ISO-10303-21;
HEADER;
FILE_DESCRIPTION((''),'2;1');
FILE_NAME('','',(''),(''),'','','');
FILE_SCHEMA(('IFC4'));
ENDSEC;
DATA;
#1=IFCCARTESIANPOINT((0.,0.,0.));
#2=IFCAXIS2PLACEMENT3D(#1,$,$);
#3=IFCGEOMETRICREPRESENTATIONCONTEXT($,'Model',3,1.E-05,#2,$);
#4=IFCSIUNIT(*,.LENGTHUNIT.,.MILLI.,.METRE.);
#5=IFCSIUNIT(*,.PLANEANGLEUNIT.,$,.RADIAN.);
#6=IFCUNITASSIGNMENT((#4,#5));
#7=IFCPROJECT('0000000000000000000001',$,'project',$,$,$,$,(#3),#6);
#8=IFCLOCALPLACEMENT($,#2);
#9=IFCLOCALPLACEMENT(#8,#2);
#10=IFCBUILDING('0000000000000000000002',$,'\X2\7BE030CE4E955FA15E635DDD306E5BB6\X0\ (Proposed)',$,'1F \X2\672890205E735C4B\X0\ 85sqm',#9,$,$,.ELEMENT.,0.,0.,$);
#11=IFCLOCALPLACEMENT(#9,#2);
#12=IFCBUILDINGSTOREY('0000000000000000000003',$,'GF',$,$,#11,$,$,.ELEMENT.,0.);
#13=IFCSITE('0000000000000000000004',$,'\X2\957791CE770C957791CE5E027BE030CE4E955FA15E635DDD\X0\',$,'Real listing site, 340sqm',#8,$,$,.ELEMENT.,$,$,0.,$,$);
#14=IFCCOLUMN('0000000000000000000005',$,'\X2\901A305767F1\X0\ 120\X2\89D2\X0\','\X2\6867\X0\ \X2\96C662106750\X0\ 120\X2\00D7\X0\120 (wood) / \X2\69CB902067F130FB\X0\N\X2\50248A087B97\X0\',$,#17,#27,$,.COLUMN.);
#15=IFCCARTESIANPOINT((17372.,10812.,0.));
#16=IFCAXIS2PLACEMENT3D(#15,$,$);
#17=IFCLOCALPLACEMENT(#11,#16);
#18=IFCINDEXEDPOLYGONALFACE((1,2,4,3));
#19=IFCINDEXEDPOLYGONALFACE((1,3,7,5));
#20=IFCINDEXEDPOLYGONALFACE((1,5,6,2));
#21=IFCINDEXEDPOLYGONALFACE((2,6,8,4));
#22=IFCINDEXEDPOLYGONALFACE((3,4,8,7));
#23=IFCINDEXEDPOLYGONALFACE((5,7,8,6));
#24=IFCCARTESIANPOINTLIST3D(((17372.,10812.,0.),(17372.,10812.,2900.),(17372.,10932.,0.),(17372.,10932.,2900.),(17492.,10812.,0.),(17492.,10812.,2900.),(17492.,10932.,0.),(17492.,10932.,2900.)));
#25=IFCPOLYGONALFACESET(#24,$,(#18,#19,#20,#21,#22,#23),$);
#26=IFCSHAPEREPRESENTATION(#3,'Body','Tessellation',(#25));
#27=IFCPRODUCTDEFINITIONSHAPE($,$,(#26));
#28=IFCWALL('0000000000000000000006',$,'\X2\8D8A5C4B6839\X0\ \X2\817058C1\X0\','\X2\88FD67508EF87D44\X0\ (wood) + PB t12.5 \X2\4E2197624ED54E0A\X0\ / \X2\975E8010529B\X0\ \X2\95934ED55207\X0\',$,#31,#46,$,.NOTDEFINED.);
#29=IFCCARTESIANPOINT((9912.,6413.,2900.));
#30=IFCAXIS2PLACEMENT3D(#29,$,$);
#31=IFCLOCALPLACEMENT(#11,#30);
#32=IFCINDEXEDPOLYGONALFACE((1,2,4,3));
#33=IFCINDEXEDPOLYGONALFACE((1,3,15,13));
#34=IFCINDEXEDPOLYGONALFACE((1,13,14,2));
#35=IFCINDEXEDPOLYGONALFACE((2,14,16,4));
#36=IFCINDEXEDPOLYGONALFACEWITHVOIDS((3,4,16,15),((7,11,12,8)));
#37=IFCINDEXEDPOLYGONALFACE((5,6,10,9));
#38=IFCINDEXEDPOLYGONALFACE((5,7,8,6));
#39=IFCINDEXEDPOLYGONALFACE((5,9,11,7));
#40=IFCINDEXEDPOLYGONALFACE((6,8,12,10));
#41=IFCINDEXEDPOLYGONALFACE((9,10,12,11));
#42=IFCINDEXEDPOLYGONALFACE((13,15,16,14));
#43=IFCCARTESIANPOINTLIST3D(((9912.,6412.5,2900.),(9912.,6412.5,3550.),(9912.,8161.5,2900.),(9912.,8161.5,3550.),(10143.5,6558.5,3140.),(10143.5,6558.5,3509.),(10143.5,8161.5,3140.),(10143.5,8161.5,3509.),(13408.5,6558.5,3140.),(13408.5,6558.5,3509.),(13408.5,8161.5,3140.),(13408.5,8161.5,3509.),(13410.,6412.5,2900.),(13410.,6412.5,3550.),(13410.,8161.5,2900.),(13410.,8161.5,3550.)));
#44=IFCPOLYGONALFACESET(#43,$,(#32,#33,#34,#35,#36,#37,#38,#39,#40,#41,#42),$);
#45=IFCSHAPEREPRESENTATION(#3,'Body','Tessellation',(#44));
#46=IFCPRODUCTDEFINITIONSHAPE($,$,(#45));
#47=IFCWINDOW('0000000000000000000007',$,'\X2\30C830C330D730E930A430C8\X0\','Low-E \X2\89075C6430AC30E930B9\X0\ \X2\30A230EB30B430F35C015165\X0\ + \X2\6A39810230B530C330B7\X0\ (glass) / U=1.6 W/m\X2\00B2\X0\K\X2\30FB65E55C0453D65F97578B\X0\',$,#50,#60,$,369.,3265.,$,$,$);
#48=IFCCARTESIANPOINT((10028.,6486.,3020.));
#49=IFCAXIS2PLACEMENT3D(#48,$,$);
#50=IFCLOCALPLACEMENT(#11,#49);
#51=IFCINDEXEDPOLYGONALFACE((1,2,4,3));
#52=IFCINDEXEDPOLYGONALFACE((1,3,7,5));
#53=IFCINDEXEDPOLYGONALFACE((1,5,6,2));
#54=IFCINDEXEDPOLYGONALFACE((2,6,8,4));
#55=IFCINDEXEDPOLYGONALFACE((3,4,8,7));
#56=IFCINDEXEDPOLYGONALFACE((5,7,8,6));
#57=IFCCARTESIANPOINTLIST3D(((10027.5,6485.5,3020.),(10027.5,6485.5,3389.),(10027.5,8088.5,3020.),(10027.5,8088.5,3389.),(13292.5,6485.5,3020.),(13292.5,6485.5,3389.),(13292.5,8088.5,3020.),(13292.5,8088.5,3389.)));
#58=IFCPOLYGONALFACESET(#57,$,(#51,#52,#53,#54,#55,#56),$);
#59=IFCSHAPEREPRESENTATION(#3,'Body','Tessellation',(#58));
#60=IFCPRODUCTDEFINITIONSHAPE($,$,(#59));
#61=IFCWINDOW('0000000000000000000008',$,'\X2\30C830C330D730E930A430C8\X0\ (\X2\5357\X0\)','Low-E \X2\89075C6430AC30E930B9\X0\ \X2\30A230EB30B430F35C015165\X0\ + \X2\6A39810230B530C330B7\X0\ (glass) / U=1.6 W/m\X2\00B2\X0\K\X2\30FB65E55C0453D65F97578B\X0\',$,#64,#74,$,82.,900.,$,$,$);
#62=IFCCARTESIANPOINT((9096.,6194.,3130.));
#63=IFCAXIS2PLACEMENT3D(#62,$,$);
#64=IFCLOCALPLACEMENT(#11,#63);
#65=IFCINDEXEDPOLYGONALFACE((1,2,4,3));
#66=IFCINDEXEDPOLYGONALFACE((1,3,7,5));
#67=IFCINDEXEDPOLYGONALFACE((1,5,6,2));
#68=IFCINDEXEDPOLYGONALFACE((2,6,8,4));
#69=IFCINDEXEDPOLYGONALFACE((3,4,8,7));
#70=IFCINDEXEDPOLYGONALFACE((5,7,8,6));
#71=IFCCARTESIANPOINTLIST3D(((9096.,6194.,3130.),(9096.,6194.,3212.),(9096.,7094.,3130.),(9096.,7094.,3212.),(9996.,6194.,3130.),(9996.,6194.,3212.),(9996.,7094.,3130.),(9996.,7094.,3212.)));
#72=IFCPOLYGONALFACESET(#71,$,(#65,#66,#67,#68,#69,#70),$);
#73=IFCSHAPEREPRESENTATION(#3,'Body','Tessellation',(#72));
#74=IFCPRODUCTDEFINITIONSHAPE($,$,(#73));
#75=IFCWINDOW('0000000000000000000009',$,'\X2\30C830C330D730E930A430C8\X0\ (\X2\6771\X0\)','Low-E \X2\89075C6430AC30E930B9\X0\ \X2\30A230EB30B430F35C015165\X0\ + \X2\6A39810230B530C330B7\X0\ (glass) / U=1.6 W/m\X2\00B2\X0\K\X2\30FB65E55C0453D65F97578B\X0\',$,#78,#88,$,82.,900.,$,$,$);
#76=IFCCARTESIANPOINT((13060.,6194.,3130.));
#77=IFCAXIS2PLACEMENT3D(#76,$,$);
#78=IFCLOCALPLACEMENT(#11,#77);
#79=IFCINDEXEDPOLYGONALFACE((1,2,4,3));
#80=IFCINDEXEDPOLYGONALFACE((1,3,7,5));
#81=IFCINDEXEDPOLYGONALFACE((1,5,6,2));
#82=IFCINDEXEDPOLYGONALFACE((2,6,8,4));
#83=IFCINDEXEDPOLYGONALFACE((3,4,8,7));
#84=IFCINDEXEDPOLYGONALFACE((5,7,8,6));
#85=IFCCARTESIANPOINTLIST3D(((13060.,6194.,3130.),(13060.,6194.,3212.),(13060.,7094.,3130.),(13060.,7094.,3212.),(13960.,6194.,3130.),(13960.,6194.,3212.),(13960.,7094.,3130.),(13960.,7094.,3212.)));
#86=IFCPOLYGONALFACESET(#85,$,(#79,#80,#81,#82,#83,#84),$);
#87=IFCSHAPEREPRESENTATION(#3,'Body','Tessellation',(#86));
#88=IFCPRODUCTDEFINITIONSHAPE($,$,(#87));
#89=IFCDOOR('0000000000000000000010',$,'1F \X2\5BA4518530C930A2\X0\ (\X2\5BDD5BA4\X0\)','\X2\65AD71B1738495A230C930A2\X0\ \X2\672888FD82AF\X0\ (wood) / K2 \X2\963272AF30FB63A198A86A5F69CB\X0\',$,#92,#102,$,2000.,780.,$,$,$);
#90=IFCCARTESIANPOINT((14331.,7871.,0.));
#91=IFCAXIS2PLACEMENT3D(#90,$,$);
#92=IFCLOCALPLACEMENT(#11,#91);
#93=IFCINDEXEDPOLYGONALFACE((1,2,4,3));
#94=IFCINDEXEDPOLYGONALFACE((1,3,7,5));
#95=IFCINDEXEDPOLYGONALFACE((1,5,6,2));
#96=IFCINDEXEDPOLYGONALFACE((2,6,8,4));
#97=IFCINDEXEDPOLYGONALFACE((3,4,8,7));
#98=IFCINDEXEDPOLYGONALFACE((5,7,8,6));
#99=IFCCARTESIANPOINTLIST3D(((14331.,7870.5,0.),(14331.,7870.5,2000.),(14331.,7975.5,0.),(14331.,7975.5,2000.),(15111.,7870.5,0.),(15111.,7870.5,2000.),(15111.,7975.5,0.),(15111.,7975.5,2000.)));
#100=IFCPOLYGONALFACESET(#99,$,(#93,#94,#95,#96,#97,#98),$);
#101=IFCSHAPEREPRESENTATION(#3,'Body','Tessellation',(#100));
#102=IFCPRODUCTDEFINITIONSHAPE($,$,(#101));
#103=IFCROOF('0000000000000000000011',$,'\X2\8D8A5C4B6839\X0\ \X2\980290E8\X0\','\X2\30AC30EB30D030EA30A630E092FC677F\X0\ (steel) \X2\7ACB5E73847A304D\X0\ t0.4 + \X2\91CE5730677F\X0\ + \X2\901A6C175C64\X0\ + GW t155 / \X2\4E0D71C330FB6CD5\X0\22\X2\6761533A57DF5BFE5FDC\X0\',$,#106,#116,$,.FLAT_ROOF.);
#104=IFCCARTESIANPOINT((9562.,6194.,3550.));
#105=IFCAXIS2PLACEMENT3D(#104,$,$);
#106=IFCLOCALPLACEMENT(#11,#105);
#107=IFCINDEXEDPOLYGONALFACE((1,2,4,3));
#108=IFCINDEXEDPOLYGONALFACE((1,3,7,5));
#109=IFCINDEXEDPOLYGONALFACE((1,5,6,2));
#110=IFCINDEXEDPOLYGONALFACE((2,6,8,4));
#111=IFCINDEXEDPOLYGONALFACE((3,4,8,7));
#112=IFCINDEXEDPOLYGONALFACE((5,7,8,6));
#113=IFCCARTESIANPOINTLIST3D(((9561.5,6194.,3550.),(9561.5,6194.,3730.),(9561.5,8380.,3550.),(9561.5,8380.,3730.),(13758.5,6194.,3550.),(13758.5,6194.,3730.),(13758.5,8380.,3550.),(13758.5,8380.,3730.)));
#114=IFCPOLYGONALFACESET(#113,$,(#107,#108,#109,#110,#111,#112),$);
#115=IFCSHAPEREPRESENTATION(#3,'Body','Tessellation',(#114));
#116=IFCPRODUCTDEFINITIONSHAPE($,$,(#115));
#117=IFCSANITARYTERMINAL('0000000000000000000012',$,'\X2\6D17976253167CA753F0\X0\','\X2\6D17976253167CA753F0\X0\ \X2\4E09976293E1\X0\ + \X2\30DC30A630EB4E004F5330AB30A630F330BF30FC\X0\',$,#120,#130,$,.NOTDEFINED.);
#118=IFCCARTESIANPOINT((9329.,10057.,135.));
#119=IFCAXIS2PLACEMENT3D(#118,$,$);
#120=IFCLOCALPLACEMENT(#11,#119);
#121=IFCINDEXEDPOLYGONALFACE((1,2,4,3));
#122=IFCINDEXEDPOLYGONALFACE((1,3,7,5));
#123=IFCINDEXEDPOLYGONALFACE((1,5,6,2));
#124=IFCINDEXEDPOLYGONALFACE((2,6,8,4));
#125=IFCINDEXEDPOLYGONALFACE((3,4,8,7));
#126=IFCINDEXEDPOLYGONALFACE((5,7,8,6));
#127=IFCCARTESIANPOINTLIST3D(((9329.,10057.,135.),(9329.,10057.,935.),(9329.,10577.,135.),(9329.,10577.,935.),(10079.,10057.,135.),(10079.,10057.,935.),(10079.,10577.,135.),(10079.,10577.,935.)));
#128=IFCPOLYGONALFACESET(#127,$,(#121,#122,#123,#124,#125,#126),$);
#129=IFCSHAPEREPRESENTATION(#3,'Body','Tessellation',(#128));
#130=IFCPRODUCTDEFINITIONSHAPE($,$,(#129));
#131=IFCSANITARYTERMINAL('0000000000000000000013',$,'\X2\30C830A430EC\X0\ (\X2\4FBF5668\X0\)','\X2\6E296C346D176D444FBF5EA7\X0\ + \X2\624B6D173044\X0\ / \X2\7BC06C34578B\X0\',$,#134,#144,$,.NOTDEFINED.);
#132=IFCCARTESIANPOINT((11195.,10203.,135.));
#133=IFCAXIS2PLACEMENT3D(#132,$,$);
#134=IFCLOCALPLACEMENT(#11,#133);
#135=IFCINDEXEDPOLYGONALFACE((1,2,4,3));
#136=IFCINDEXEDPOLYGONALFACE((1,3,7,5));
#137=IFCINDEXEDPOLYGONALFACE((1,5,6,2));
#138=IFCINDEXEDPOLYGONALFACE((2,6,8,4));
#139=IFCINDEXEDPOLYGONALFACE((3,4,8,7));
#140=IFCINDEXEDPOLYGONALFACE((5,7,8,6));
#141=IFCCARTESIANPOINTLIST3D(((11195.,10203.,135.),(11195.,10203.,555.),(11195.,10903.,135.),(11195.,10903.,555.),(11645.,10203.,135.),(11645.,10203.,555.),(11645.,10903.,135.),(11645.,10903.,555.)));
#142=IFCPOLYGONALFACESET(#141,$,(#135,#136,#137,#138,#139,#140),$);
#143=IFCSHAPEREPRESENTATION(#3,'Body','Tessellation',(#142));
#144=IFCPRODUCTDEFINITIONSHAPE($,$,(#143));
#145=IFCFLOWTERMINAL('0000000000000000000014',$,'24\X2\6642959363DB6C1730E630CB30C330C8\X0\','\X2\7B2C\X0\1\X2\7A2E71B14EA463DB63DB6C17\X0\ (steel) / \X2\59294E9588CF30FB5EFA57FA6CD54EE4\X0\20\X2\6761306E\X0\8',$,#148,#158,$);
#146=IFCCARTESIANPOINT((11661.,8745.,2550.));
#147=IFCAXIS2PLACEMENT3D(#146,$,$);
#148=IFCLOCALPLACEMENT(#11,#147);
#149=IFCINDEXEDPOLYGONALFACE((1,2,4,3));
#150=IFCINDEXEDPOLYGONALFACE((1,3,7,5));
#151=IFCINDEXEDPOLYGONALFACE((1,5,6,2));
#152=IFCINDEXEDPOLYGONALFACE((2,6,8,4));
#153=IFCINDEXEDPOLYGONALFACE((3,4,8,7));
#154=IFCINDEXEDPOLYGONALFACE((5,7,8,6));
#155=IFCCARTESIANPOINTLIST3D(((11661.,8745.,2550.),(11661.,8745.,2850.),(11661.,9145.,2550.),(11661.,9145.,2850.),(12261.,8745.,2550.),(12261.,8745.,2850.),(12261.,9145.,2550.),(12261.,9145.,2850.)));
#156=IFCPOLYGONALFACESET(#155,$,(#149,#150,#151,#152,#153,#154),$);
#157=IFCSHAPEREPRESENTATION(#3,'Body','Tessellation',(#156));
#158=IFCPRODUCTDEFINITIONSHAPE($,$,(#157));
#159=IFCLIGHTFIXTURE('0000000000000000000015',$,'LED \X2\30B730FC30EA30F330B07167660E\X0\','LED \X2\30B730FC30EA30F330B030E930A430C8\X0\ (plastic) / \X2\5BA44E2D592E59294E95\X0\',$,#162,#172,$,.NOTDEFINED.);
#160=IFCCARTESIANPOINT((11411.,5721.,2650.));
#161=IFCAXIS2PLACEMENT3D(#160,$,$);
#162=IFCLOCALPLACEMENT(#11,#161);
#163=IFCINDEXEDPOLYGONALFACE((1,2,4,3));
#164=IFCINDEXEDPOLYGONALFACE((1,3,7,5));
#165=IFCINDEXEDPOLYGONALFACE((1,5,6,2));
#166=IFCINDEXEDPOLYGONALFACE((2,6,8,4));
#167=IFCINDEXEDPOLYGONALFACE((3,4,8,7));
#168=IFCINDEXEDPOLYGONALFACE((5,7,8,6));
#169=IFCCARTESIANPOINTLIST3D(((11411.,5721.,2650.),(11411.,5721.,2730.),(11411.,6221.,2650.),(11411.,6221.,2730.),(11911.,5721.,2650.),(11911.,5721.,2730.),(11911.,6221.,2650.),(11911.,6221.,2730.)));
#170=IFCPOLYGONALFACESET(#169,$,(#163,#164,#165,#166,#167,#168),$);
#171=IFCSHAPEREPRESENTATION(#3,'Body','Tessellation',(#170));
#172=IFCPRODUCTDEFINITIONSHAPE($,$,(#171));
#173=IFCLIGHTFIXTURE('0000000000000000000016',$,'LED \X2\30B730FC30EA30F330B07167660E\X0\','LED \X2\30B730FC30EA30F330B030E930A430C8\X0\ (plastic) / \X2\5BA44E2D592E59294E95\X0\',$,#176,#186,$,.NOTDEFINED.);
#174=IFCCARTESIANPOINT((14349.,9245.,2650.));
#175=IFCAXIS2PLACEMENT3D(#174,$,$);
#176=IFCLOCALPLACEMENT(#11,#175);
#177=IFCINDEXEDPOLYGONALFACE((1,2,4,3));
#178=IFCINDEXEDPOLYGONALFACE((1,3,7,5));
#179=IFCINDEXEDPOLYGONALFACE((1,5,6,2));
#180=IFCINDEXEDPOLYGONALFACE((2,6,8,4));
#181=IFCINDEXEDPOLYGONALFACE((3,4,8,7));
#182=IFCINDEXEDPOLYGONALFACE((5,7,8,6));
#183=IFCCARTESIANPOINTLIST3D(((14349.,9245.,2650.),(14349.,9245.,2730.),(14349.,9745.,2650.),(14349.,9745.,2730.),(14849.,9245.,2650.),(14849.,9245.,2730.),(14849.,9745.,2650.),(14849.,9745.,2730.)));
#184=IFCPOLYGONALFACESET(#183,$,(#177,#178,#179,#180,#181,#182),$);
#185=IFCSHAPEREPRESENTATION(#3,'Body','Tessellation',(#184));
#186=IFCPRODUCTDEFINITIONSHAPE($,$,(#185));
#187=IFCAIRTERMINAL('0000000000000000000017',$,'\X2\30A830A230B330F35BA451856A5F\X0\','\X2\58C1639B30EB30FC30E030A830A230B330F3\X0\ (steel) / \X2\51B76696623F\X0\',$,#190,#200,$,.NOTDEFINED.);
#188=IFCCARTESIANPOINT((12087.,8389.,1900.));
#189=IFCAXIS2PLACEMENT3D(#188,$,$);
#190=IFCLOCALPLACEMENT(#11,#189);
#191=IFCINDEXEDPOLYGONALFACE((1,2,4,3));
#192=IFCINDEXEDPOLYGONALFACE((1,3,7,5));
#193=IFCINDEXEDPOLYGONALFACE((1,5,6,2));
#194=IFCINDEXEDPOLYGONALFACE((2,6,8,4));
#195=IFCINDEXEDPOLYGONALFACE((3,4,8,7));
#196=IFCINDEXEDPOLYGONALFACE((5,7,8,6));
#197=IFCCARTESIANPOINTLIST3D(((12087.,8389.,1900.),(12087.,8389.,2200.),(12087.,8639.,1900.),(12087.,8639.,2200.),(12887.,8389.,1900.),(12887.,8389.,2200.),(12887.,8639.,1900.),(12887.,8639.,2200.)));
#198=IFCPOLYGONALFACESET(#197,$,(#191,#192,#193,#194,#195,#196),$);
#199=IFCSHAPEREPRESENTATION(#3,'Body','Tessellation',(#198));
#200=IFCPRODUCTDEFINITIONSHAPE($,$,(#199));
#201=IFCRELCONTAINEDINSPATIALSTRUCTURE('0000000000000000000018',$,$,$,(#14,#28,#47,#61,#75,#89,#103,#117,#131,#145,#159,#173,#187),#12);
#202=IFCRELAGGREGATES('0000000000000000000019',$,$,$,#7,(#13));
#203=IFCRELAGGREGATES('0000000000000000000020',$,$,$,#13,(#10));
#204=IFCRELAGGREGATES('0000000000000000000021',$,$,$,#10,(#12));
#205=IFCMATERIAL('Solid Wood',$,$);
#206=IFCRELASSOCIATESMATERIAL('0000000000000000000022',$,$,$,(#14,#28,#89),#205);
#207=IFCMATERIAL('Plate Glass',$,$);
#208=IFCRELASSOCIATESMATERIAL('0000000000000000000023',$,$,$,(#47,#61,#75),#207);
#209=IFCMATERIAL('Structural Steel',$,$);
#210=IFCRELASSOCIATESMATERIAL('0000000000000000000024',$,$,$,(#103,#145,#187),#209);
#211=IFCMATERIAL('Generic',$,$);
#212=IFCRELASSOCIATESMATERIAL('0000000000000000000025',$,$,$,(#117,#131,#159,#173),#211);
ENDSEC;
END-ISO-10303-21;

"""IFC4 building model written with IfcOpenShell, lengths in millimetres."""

from ifc_helpers import new_model, si_unit, frame, frame_2d, origin, place, context, project, spatial, rectangle, extrude, material, element, fill, save


model = new_model("IFC4")

# Units and contexts
model_context = context("Model", 3, precision=1e-05, world=origin())
ifc_project = project(units=[si_unit("LENGTHUNIT", "METRE", prefix="MILLI"), si_unit("PLANEANGLEUNIT", "RADIAN")], contexts=[model_context])

# Site, building, storey
site_placement = place(None, origin())
site = spatial("IfcSite", under=ifc_project, at=site_placement, Name="長野県長野市篠ノ井御幣川", ObjectType="Real listing site, 340sqm", CompositionType="ELEMENT", RefElevation=0.0)
building_placement = place(site_placement, origin())
building = spatial("IfcBuilding", under=site, at=building_placement, Name="篠ノ井御幣川の家 (Proposed)", ObjectType="1F 木造平屋 85sqm", CompositionType="ELEMENT", ElevationOfRefHeight=0.0, ElevationOfTerrain=0.0)
storey_placement = place(building_placement, origin())
storey = spatial("IfcBuildingStorey", under=building, at=storey_placement, Name="GF", CompositionType="ELEMENT", Elevation=0.0)

# Column
ifc_material_1 = material(Name="Solid Wood")
column_1_placement = place(storey_placement, frame((17372.0, 10812.0, 0.0)))
element("IfcColumn", 1, at=column_1_placement, inside=storey, material=ifc_material_1, Name="通し柱 120角", Description="桧 集成材 120×120 (wood) / 構造柱・N値計算", PredefinedType="COLUMN", context=model_context, shape_type="SweptSolid", body=[
    extrude(rectangle(XDim=120.0, YDim=120.0, at=frame_2d((60.0, 60.0))), frame((17372.0, 10812.0, 0.0)), (0.0, 0.0, 1.0), 2900.0),
])

# Wall, openings, windows
wall_1_placement = place(storey_placement, frame((9912.0, 6413.0, 2900.0)))
wall_1 = element("IfcWall", 2, at=wall_1_placement, inside=storey, material=ifc_material_1, Name="越屋根 腰壁", Description="製材軸組 (wood) + PB t12.5 両面仕上 / 非耐力 間仕切", PredefinedType="NOTDEFINED", context=model_context, shape_type="SweptSolid", body=[
    extrude(rectangle(XDim=3498.0, YDim=1749.0, at=frame_2d((1749.0, 874.0))), frame((9912.0, 6413.0, 2900.0)), (0.0, 0.0, 1.0), 650.0),
])
opening_1_placement = place(storey_placement, frame((10028.0, 6486.0, 3020.0)))
opening_1 = element("IfcOpeningElement", 3, at=opening_1_placement, cuts=wall_1, PredefinedType="NOTDEFINED", context=model_context, shape_type="SweptSolid", body=[
    extrude(rectangle(XDim=3265.0, YDim=1603.0, at=frame_2d((1632.0, 801.0))), frame((10028.0, 6486.0, 3020.0)), (0.0, 0.0, 1.0), 369.0),
])
opening_2_placement = place(storey_placement, frame((9096.0, 6194.0, 3130.0)))
opening_2 = element("IfcOpeningElement", 4, at=opening_2_placement, cuts=wall_1, PredefinedType="NOTDEFINED", context=model_context, shape_type="SweptSolid", body=[
    extrude(rectangle(XDim=900.0, YDim=900.0, at=frame_2d((450.0, 450.0))), frame((9096.0, 6194.0, 3130.0)), (0.0, 0.0, 1.0), 82.0),
])
opening_3_placement = place(storey_placement, frame((13060.0, 6194.0, 3130.0)))
opening_3 = element("IfcOpeningElement", 5, at=opening_3_placement, cuts=wall_1, PredefinedType="NOTDEFINED", context=model_context, shape_type="SweptSolid", body=[
    extrude(rectangle(XDim=900.0, YDim=900.0, at=frame_2d((450.0, 450.0))), frame((13060.0, 6194.0, 3130.0)), (0.0, 0.0, 1.0), 82.0),
])
ifc_material_2 = material(Name="Plate Glass")
window_1_placement = place(storey_placement, frame((10028.0, 6486.0, 3020.0)))
window_1 = element("IfcWindow", 6, at=window_1_placement, inside=storey, material=ifc_material_2, Name="トップライト", Description="Low-E 複層ガラス アルゴン封入 + 樹脂サッシ (glass) / U=1.6 W/m²K・日射取得型", OverallHeight=369.0, OverallWidth=3265.0, context=model_context, shape_type="SweptSolid", body=[
    extrude(rectangle(XDim=3265.0, YDim=1603.0, at=frame_2d((1632.0, 801.0))), frame((10028.0, 6486.0, 3020.0)), (0.0, 0.0, 1.0), 369.0),
])
fill(opening_1, window_1)
window_2_placement = place(storey_placement, frame((9096.0, 6194.0, 3130.0)))
window_2 = element("IfcWindow", 7, at=window_2_placement, inside=storey, material=ifc_material_2, Name="トップライト (南)", Description="Low-E 複層ガラス アルゴン封入 + 樹脂サッシ (glass) / U=1.6 W/m²K・日射取得型", OverallHeight=82.0, OverallWidth=900.0, context=model_context, shape_type="SweptSolid", body=[
    extrude(rectangle(XDim=900.0, YDim=900.0, at=frame_2d((450.0, 450.0))), frame((9096.0, 6194.0, 3130.0)), (0.0, 0.0, 1.0), 82.0),
])
fill(opening_2, window_2)
window_3_placement = place(storey_placement, frame((13060.0, 6194.0, 3130.0)))
window_3 = element("IfcWindow", 8, at=window_3_placement, inside=storey, material=ifc_material_2, Name="トップライト (東)", Description="Low-E 複層ガラス アルゴン封入 + 樹脂サッシ (glass) / U=1.6 W/m²K・日射取得型", OverallHeight=82.0, OverallWidth=900.0, context=model_context, shape_type="SweptSolid", body=[
    extrude(rectangle(XDim=900.0, YDim=900.0, at=frame_2d((450.0, 450.0))), frame((13060.0, 6194.0, 3130.0)), (0.0, 0.0, 1.0), 82.0),
])
fill(opening_3, window_3)

# Door
door_placement = place(storey_placement, frame((14331.0, 7871.0, 0.0)))
element("IfcDoor", 9, at=door_placement, inside=storey, material=ifc_material_1, Name="1F 室内ドア (寝室)", Description="断熱玄関ドア 木製芯 (wood) / K2 防犯・採風機構", OverallHeight=2000.0, OverallWidth=780.0, context=model_context, shape_type="SweptSolid", body=[
    extrude(rectangle(XDim=780.0, YDim=105.0, at=frame_2d((390.0, 52.0))), frame((14331.0, 7871.0, 0.0)), (0.0, 0.0, 1.0), 2000.0),
])

# Roof
ifc_material_3 = material(Name="Structural Steel")
roof_placement = place(storey_placement, frame((9562.0, 6194.0, 3550.0)))
element("IfcRoof", 10, at=roof_placement, inside=storey, material=ifc_material_3, Name="越屋根 頂部", Description="ガルバリウム鋼板 (steel) 立平葺き t0.4 + 野地板 + 通気層 + GW t155 / 不燃・法22条区域対応", PredefinedType="FLAT_ROOF", context=model_context, shape_type="SweptSolid", body=[
    extrude(rectangle(XDim=4197.0, YDim=2186.0, at=frame_2d((2098.0, 1093.0))), frame((9562.0, 6194.0, 3550.0)), (0.0, 0.0, 1.0), 180.0),
])

# Sanitary terminals
ifc_material_4 = material(Name="Generic")
sanitary_terminal_1_placement = place(storey_placement, frame((9329.0, 10057.0, 135.0)))
element("IfcSanitaryTerminal", 11, at=sanitary_terminal_1_placement, inside=storey, material=ifc_material_4, Name="洗面化粧台", Description="洗面化粧台 三面鏡 + ボウル一体カウンター", PredefinedType="NOTDEFINED", context=model_context, shape_type="SweptSolid", body=[
    extrude(rectangle(XDim=750.0, YDim=520.0, at=frame_2d((375.0, 260.0))), frame((9329.0, 10057.0, 135.0)), (0.0, 0.0, 1.0), 800.0),
])
sanitary_terminal_2_placement = place(storey_placement, frame((11195.0, 10203.0, 135.0)))
element("IfcSanitaryTerminal", 12, at=sanitary_terminal_2_placement, inside=storey, material=ifc_material_4, Name="トイレ (便器)", Description="温水洗浄便座 + 手洗い / 節水型", PredefinedType="NOTDEFINED", context=model_context, shape_type="SweptSolid", body=[
    extrude(rectangle(XDim=450.0, YDim=700.0, at=frame_2d((225.0, 350.0))), frame((11195.0, 10203.0, 135.0)), (0.0, 0.0, 1.0), 420.0),
])

# Flow terminal
flow_terminal_placement = place(storey_placement, frame((11661.0, 8745.0, 2550.0)))
element("IfcFlowTerminal", 13, at=flow_terminal_placement, inside=storey, material=ifc_material_3, Name="24時間換気ユニット", Description="第1種熱交換換気 (steel) / 天井裏・建基法令20条の8", context=model_context, shape_type="SweptSolid", body=[
    extrude(rectangle(XDim=600.0, YDim=400.0, at=frame_2d((300.0, 200.0))), frame((11661.0, 8745.0, 2550.0)), (0.0, 0.0, 1.0), 300.0),
])

# Light fixtures
light_fixture_1_placement = place(storey_placement, frame((11411.0, 5721.0, 2650.0)))
element("IfcLightFixture", 14, at=light_fixture_1_placement, inside=storey, material=ifc_material_4, Name="LED シーリング照明", Description="LED シーリングライト (plastic) / 室中央天井", PredefinedType="NOTDEFINED", context=model_context, shape_type="SweptSolid", body=[
    extrude(rectangle(XDim=500.0, YDim=500.0, at=frame_2d((250.0, 250.0))), frame((11411.0, 5721.0, 2650.0)), (0.0, 0.0, 1.0), 80.0),
])
light_fixture_2_placement = place(storey_placement, frame((14349.0, 9245.0, 2650.0)))
element("IfcLightFixture", 15, at=light_fixture_2_placement, inside=storey, material=ifc_material_4, Name="LED シーリング照明", Description="LED シーリングライト (plastic) / 室中央天井", PredefinedType="NOTDEFINED", context=model_context, shape_type="SweptSolid", body=[
    extrude(rectangle(XDim=500.0, YDim=500.0, at=frame_2d((250.0, 250.0))), frame((14349.0, 9245.0, 2650.0)), (0.0, 0.0, 1.0), 80.0),
])

# Air terminal
air_terminal_placement = place(storey_placement, frame((12087.0, 8389.0, 1900.0)))
element("IfcAirTerminal", 16, at=air_terminal_placement, inside=storey, material=ifc_material_3, Name="エアコン室内機", Description="壁掛ルームエアコン (steel) / 冷暖房", PredefinedType="NOTDEFINED", context=model_context, shape_type="SweptSolid", body=[
    extrude(rectangle(XDim=800.0, YDim=250.0, at=frame_2d((400.0, 125.0))), frame((12087.0, 8389.0, 1900.0)), (0.0, 0.0, 1.0), 300.0),
])

save(model, "model.ifc")
